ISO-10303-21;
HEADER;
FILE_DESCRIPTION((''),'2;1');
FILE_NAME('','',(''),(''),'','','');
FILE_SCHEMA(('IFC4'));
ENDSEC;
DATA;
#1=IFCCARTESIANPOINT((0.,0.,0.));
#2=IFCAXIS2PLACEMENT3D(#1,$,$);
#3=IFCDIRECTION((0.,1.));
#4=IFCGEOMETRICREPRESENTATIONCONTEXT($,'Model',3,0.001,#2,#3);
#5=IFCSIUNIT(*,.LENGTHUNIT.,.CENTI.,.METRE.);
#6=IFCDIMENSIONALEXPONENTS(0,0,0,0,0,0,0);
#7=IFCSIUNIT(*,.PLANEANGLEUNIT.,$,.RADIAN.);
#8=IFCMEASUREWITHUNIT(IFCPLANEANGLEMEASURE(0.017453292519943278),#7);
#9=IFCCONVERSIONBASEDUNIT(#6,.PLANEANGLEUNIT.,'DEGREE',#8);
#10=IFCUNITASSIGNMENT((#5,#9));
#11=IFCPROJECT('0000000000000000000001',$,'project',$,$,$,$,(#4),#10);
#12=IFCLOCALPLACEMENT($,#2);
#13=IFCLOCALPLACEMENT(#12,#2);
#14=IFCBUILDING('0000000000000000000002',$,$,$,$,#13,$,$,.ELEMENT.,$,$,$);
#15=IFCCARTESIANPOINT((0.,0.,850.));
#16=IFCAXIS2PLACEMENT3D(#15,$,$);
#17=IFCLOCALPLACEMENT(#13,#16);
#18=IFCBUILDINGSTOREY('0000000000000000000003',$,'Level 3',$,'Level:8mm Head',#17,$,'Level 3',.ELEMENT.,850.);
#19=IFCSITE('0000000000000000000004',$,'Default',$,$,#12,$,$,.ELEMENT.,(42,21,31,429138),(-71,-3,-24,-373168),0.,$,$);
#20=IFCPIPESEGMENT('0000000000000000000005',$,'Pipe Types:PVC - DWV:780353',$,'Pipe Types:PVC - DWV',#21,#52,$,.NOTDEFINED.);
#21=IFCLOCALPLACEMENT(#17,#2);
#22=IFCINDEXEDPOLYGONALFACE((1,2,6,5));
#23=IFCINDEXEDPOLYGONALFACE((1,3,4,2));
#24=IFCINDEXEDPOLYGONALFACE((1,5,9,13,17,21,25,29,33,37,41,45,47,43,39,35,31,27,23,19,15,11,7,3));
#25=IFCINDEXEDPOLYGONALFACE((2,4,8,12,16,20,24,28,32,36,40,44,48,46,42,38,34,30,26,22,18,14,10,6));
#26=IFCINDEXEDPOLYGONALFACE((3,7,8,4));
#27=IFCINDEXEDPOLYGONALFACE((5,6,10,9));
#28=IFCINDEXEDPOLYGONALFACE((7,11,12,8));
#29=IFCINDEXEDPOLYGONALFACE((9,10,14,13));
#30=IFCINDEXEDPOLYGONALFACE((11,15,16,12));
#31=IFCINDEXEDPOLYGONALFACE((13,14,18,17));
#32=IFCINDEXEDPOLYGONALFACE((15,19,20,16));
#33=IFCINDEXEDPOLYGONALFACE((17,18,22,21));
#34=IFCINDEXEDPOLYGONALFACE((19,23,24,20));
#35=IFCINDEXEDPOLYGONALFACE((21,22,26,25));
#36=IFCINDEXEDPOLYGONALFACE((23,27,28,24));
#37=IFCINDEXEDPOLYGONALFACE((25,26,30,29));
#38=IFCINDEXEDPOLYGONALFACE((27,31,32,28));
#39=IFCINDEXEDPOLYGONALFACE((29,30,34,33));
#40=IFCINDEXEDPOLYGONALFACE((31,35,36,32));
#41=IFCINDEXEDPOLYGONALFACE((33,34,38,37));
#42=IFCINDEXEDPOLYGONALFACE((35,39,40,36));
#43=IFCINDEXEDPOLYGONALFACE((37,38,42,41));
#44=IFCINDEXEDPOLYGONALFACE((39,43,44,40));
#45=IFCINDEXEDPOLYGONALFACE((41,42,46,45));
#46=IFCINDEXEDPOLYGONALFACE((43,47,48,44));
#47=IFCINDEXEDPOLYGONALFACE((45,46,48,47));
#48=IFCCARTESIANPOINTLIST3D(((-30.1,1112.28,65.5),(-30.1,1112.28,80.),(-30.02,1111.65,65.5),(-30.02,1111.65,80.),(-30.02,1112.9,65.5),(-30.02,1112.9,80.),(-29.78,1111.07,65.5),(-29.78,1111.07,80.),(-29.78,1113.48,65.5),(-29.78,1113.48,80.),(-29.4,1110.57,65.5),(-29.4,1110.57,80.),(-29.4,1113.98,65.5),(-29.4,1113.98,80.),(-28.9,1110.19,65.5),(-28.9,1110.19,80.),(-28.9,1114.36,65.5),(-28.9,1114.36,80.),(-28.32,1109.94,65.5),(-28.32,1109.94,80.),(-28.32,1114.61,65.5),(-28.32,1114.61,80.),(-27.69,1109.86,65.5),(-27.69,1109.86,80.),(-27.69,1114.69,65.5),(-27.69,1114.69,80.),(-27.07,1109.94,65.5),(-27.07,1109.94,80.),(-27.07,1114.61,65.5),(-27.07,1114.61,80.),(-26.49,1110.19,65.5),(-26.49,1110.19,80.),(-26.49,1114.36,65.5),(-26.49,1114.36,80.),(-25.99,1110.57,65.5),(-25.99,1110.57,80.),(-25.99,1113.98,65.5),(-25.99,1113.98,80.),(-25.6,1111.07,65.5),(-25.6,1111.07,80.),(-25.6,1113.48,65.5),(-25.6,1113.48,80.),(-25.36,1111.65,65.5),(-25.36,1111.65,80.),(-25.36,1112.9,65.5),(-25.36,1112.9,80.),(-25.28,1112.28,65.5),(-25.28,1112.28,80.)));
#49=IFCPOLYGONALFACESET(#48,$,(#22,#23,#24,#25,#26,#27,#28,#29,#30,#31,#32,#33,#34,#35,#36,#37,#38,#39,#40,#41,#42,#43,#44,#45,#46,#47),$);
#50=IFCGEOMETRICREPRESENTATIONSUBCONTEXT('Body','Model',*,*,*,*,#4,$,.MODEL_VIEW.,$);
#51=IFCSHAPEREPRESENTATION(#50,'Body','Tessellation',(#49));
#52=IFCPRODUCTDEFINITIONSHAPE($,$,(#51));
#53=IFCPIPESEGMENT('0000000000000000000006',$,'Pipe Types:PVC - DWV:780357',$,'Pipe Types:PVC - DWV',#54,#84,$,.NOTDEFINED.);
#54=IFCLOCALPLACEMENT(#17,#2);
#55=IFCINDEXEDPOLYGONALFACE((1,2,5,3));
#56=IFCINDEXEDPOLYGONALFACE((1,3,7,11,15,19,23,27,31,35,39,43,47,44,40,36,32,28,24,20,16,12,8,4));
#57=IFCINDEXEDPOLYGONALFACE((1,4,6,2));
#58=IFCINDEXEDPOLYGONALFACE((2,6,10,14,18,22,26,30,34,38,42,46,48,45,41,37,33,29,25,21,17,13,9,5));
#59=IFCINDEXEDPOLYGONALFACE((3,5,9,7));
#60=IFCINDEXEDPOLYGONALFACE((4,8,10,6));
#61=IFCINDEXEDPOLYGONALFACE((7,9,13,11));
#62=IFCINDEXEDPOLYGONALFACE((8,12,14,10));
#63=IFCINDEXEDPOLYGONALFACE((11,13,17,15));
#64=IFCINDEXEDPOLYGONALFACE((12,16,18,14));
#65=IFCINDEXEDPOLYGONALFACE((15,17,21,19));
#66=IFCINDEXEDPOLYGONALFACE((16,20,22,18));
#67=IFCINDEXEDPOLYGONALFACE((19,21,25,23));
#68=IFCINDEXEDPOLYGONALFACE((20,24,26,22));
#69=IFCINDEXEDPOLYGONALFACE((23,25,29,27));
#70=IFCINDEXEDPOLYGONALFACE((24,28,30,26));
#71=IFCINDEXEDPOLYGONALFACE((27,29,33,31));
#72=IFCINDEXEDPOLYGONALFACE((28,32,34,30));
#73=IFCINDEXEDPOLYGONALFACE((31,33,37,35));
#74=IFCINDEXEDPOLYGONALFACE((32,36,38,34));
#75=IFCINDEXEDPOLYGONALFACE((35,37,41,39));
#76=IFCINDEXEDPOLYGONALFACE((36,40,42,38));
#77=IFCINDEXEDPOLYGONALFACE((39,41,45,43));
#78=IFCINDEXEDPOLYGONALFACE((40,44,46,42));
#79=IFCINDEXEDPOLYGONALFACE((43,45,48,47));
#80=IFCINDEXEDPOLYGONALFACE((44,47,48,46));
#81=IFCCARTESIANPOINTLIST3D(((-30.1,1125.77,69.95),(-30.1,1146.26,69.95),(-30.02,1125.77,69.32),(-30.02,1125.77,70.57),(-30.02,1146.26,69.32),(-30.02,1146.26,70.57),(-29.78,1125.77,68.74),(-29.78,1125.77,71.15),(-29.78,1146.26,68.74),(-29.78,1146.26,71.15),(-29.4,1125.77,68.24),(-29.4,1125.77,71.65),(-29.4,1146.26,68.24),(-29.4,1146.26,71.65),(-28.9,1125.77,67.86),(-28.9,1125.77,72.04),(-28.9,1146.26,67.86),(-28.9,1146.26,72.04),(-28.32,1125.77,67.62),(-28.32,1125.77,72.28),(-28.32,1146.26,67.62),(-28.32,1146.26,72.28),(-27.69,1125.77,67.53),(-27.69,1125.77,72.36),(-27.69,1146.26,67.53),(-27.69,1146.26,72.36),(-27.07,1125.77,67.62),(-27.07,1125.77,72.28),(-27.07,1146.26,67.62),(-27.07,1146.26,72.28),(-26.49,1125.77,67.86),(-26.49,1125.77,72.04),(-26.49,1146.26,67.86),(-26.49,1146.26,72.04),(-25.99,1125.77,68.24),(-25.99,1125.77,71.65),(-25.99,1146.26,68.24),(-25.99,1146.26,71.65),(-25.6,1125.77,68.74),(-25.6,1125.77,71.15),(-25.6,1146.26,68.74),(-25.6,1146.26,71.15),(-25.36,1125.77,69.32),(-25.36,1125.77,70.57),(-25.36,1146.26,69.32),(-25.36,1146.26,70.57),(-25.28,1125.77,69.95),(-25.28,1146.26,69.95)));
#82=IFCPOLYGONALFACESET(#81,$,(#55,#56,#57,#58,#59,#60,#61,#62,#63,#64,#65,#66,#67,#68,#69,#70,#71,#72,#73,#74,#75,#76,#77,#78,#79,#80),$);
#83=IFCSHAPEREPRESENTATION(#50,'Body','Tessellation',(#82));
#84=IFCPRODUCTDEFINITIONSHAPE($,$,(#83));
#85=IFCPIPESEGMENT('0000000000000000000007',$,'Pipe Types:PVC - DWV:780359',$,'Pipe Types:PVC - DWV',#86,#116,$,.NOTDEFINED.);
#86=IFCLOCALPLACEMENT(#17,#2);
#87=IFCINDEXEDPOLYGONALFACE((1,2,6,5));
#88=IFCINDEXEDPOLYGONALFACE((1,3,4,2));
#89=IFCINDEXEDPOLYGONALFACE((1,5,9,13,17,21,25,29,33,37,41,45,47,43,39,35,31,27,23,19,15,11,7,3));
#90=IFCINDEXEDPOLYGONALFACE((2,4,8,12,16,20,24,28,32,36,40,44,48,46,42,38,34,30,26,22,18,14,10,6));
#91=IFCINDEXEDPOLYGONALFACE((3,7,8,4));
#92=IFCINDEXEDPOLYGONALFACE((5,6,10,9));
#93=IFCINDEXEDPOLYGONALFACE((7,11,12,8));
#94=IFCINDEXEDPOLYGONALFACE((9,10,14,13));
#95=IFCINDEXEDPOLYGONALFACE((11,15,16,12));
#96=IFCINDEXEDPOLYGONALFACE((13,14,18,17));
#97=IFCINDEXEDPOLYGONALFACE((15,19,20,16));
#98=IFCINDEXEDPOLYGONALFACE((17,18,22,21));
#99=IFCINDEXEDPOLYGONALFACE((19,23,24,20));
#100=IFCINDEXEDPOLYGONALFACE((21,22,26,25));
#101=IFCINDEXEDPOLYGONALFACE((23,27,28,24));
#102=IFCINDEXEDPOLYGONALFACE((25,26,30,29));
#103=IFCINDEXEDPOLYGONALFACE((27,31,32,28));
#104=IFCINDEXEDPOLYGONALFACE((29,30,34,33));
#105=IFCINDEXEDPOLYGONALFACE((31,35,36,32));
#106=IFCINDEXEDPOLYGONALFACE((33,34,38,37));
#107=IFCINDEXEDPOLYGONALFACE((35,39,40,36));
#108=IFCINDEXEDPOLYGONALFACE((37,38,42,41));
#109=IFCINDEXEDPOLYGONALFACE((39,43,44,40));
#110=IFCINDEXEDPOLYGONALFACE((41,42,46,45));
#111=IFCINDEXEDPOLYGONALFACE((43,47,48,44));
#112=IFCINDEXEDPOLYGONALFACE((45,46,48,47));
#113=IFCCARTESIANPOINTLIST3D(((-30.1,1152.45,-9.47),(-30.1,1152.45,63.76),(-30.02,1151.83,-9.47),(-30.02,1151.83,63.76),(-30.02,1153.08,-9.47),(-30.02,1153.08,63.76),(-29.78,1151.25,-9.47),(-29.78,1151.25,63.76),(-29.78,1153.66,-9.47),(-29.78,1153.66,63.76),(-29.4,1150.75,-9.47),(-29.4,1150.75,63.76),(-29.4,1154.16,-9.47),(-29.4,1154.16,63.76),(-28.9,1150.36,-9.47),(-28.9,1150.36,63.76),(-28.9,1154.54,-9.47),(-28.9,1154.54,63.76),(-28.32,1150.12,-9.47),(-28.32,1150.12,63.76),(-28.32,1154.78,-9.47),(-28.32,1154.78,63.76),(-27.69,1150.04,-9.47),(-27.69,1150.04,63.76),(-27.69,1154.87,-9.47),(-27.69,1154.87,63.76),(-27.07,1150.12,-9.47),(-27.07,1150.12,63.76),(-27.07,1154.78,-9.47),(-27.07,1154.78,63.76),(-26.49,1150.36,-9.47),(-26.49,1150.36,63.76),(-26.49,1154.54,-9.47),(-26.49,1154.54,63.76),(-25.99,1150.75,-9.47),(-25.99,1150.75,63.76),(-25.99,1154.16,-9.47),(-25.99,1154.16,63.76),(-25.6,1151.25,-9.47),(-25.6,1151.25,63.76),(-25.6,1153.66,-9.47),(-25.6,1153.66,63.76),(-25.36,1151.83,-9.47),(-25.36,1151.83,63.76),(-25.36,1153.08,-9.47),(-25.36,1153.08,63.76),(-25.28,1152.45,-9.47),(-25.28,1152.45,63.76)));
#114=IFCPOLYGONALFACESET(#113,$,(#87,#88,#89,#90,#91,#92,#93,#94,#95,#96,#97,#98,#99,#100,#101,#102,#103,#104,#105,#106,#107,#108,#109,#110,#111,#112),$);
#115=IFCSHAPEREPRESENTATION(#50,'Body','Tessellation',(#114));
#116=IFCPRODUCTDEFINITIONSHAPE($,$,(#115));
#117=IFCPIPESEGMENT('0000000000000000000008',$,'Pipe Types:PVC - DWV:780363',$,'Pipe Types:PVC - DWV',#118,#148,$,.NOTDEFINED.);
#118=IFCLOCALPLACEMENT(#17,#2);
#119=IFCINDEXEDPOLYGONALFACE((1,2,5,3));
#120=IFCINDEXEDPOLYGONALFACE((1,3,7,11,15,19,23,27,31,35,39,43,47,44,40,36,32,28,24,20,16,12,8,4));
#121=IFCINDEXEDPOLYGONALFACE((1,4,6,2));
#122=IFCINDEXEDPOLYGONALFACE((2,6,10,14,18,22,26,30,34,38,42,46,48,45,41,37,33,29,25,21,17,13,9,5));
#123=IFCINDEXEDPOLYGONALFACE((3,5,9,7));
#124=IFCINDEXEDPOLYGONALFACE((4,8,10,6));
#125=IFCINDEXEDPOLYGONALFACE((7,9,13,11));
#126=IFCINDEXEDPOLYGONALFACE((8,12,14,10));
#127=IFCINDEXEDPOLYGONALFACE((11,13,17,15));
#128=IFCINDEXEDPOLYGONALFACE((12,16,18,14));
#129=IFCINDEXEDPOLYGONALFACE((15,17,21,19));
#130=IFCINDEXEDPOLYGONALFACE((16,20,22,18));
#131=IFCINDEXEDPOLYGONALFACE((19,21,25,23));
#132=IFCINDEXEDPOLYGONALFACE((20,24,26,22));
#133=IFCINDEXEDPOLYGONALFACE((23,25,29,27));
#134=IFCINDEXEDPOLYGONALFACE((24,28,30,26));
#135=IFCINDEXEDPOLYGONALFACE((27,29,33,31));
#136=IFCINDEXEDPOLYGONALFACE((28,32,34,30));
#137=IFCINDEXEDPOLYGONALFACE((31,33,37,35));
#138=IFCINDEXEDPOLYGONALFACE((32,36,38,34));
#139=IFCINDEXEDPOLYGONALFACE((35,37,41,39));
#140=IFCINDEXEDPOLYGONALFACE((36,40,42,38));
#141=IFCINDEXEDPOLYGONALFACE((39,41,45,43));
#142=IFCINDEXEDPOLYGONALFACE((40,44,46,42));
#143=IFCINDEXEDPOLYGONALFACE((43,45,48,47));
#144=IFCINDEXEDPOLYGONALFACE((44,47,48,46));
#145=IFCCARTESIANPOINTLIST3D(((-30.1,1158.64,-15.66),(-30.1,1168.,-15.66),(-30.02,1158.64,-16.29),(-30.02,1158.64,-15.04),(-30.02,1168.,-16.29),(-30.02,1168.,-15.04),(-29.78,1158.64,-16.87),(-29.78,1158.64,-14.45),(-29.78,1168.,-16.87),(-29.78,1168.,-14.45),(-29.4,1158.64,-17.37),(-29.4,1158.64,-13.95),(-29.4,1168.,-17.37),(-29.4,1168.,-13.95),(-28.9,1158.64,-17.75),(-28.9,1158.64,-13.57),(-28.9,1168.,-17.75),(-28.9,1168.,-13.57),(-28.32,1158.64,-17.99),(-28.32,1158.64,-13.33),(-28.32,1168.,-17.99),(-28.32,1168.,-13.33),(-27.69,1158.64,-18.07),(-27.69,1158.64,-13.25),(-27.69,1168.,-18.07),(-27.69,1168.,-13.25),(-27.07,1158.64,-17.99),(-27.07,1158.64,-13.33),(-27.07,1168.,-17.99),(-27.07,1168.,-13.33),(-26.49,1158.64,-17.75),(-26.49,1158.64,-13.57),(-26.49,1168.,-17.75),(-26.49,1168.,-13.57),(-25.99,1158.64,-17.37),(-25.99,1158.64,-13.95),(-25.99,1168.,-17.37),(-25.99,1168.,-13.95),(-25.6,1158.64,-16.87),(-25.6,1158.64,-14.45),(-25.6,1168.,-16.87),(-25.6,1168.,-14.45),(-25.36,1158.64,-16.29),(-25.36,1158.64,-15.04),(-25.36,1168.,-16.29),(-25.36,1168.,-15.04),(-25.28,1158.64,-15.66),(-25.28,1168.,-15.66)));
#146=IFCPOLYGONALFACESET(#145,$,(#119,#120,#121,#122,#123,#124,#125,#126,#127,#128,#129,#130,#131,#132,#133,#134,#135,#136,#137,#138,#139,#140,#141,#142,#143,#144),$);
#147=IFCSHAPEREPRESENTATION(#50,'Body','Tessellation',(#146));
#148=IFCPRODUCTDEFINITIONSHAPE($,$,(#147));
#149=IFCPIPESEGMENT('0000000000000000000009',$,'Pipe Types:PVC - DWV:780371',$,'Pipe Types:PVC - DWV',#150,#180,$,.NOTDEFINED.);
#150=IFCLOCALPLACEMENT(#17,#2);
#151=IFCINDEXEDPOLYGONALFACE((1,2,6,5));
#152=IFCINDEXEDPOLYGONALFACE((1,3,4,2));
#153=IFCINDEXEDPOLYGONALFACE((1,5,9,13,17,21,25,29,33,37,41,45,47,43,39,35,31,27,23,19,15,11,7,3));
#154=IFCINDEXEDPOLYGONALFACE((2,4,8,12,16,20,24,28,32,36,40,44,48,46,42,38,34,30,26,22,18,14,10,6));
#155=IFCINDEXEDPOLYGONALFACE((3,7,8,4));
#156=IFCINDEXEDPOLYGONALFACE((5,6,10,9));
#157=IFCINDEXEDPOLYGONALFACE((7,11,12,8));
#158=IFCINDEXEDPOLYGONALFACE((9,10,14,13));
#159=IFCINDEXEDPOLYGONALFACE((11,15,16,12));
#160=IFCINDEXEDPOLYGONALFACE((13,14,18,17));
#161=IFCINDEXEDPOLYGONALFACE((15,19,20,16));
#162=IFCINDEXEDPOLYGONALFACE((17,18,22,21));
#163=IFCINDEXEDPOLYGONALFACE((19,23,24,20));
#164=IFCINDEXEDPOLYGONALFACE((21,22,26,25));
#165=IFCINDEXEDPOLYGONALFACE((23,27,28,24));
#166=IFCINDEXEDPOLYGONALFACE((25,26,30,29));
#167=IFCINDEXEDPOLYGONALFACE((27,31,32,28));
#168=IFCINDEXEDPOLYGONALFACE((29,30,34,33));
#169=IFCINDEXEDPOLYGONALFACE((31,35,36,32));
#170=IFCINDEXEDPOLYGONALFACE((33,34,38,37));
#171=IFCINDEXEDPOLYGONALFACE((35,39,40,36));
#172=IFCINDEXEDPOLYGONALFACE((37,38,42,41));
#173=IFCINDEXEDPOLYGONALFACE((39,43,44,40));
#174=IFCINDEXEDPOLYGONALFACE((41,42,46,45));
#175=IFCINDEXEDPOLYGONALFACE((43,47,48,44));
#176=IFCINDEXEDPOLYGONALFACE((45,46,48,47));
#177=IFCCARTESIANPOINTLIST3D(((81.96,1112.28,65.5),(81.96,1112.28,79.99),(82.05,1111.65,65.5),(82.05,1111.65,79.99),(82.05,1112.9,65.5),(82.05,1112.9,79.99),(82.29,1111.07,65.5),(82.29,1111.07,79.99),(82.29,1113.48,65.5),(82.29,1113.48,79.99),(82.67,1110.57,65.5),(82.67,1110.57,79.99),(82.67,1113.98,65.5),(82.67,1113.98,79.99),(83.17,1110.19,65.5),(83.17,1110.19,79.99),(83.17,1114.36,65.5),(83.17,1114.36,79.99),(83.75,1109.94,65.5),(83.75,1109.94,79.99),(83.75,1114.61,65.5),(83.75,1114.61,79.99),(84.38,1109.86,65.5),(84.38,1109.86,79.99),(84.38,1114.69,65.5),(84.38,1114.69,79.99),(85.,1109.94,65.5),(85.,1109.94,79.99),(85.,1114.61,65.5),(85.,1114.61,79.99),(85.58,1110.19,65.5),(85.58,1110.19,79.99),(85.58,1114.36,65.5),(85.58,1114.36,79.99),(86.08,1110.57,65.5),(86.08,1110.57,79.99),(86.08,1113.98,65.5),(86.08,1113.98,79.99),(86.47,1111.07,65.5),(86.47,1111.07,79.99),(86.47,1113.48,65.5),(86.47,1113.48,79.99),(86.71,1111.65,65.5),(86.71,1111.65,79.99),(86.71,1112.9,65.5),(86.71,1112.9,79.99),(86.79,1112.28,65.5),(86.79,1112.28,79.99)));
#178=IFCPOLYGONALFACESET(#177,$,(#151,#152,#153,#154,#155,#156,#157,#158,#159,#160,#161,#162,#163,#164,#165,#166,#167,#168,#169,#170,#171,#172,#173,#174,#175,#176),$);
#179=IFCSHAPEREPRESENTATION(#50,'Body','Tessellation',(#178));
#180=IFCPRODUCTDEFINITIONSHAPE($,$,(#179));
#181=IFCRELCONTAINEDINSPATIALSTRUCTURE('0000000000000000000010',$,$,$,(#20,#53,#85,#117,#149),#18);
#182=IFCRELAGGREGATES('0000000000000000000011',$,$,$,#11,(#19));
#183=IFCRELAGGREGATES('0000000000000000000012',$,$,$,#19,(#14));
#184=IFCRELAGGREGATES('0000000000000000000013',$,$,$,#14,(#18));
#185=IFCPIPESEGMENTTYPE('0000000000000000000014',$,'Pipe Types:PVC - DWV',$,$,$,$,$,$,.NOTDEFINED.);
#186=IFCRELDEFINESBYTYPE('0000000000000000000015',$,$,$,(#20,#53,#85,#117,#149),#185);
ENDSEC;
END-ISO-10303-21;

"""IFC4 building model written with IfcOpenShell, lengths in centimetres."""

from ifc_helpers import new_model, entity, si_unit, converted_unit, direction, frame, origin, place, context, subcontext, project, spatial, arc, indexed_curve, outline, extrude, type_object, element, save


model = new_model("IFC4")

# Units and contexts
model_context = context("Model", 3, precision=0.001, world=origin(), true_north=direction((0.0, 1.0)))
body_context = subcontext(model_context, "Body", "Model", "MODEL_VIEW")
ifc_project = project(units=[si_unit("LENGTHUNIT", "METRE", prefix="CENTI"), converted_unit("PLANEANGLEUNIT", "DEGREE", entity("IfcPlaneAngleMeasure", 0.017453292519943278), si_unit("PLANEANGLEUNIT", "RADIAN"), dimensions=[0, 0, 0, 0, 0, 0, 0])], contexts=[model_context])

# Site, building, storey
site_placement = place(None, origin())
site = spatial("IfcSite", under=ifc_project, at=site_placement, Name="Default", CompositionType="ELEMENT", RefLatitude=(42, 21, 31, 429138), RefLongitude=(-71, -3, -24, -373168), RefElevation=0.0)
building_placement = place(site_placement, origin())
building = spatial("IfcBuilding", under=site, at=building_placement, CompositionType="ELEMENT")
storey_placement = place(building_placement, frame((0.0, 0.0, 850.0)))
storey = spatial("IfcBuildingStorey", under=building, at=storey_placement, Name="Level 3", ObjectType="Level:8mm Head", LongName="Level 3", CompositionType="ELEMENT", Elevation=850.0)

# Pipe segments
pipe_segment_type = type_object("IfcPipeSegmentType", Name="Pipe Types:PVC - DWV", PredefinedType="NOTDEFINED")
pipe_segment_1_placement = place(storey_placement, origin())
element("IfcPipeSegment", 1, at=pipe_segment_1_placement, inside=storey, type_object=pipe_segment_type, Name="Pipe Types:PVC - DWV:780353", ObjectType="Pipe Types:PVC - DWV", PredefinedType="NOTDEFINED", context=body_context, shape_type="SweptSolid", body=[
    extrude(outline(indexed_curve([(2.41, 0.0), (1.71, 1.71), (0.0, 2.41), (-1.71, 1.71), (-2.41, 0.0), (-1.71, -1.71), (0.0, -2.41), (1.71, -1.71)], segments=[arc(1, 2, 3), arc(3, 4, 5), arc(5, 6, 7), arc(7, 8, 1)], self_intersect=False)), frame((-27.69, 1112.28, 65.5)), (0.0, 0.0, 1.0), 14.5),
])
pipe_segment_2_placement = place(storey_placement, origin())
element("IfcPipeSegment", 2, at=pipe_segment_2_placement, inside=storey, type_object=pipe_segment_type, Name="Pipe Types:PVC - DWV:780357", ObjectType="Pipe Types:PVC - DWV", PredefinedType="NOTDEFINED", context=body_context, shape_type="SweptSolid", body=[
    extrude(outline(indexed_curve([(2.41, 0.0), (1.71, 1.71), (0.0, 2.41), (-1.71, 1.71), (-2.41, 0.0), (-1.71, -1.71), (0.0, -2.41), (1.71, -1.71)], segments=[arc(1, 2, 3), arc(3, 4, 5), arc(5, 6, 7), arc(7, 8, 1)], self_intersect=False)), frame((-27.69, 1125.77, 69.95), z_axis=(0.0, 1.0, 0.0), x_axis=(1.0, 0.0, 0.0)), (0.0, 0.0, 1.0), 20.5),
])
pipe_segment_3_placement = place(storey_placement, origin())
element("IfcPipeSegment", 3, at=pipe_segment_3_placement, inside=storey, type_object=pipe_segment_type, Name="Pipe Types:PVC - DWV:780359", ObjectType="Pipe Types:PVC - DWV", PredefinedType="NOTDEFINED", context=body_context, shape_type="SweptSolid", body=[
    extrude(outline(indexed_curve([(2.41, 0.0), (1.71, 1.71), (0.0, 2.41), (-1.71, 1.71), (-2.41, 0.0), (-1.71, -1.71), (0.0, -2.41), (1.71, -1.71)], segments=[arc(1, 2, 3), arc(3, 4, 5), arc(5, 6, 7), arc(7, 8, 1)], self_intersect=False)), frame((-27.69, 1152.45, -9.47)), (0.0, 0.0, 1.0), 73.23),
])
pipe_segment_4_placement = place(storey_placement, origin())
element("IfcPipeSegment", 4, at=pipe_segment_4_placement, inside=storey, type_object=pipe_segment_type, Name="Pipe Types:PVC - DWV:780363", ObjectType="Pipe Types:PVC - DWV", PredefinedType="NOTDEFINED", context=body_context, shape_type="SweptSolid", body=[
    extrude(outline(indexed_curve([(2.41, 0.0), (1.71, 1.71), (0.0, 2.41), (-1.71, 1.71), (-2.41, 0.0), (-1.71, -1.71), (0.0, -2.41), (1.71, -1.71)], segments=[arc(1, 2, 3), arc(3, 4, 5), arc(5, 6, 7), arc(7, 8, 1)], self_intersect=False)), frame((-27.69, 1158.64, -15.66), z_axis=(0.0, 1.0, 0.0), x_axis=(1.0, 0.0, 0.0)), (0.0, 0.0, 1.0), 9.36),
])
pipe_segment_5_placement = place(storey_placement, origin())
element("IfcPipeSegment", 5, at=pipe_segment_5_placement, inside=storey, type_object=pipe_segment_type, Name="Pipe Types:PVC - DWV:780371", ObjectType="Pipe Types:PVC - DWV", PredefinedType="NOTDEFINED", context=body_context, shape_type="SweptSolid", body=[
    extrude(outline(indexed_curve([(2.41, 0.0), (1.71, 1.71), (0.0, 2.41), (-1.71, 1.71), (-2.41, 0.0), (-1.71, -1.71), (0.0, -2.41), (1.71, -1.71)], segments=[arc(1, 2, 3), arc(3, 4, 5), arc(5, 6, 7), arc(7, 8, 1)], self_intersect=False)), frame((84.38, 1112.28, 65.5), z_axis=(0.0, 0.0, 1.0), x_axis=(-1.0, 0.0, 0.0)), (0.0, 0.0, 1.0), 14.49),
])

save(model, "model.ifc")
